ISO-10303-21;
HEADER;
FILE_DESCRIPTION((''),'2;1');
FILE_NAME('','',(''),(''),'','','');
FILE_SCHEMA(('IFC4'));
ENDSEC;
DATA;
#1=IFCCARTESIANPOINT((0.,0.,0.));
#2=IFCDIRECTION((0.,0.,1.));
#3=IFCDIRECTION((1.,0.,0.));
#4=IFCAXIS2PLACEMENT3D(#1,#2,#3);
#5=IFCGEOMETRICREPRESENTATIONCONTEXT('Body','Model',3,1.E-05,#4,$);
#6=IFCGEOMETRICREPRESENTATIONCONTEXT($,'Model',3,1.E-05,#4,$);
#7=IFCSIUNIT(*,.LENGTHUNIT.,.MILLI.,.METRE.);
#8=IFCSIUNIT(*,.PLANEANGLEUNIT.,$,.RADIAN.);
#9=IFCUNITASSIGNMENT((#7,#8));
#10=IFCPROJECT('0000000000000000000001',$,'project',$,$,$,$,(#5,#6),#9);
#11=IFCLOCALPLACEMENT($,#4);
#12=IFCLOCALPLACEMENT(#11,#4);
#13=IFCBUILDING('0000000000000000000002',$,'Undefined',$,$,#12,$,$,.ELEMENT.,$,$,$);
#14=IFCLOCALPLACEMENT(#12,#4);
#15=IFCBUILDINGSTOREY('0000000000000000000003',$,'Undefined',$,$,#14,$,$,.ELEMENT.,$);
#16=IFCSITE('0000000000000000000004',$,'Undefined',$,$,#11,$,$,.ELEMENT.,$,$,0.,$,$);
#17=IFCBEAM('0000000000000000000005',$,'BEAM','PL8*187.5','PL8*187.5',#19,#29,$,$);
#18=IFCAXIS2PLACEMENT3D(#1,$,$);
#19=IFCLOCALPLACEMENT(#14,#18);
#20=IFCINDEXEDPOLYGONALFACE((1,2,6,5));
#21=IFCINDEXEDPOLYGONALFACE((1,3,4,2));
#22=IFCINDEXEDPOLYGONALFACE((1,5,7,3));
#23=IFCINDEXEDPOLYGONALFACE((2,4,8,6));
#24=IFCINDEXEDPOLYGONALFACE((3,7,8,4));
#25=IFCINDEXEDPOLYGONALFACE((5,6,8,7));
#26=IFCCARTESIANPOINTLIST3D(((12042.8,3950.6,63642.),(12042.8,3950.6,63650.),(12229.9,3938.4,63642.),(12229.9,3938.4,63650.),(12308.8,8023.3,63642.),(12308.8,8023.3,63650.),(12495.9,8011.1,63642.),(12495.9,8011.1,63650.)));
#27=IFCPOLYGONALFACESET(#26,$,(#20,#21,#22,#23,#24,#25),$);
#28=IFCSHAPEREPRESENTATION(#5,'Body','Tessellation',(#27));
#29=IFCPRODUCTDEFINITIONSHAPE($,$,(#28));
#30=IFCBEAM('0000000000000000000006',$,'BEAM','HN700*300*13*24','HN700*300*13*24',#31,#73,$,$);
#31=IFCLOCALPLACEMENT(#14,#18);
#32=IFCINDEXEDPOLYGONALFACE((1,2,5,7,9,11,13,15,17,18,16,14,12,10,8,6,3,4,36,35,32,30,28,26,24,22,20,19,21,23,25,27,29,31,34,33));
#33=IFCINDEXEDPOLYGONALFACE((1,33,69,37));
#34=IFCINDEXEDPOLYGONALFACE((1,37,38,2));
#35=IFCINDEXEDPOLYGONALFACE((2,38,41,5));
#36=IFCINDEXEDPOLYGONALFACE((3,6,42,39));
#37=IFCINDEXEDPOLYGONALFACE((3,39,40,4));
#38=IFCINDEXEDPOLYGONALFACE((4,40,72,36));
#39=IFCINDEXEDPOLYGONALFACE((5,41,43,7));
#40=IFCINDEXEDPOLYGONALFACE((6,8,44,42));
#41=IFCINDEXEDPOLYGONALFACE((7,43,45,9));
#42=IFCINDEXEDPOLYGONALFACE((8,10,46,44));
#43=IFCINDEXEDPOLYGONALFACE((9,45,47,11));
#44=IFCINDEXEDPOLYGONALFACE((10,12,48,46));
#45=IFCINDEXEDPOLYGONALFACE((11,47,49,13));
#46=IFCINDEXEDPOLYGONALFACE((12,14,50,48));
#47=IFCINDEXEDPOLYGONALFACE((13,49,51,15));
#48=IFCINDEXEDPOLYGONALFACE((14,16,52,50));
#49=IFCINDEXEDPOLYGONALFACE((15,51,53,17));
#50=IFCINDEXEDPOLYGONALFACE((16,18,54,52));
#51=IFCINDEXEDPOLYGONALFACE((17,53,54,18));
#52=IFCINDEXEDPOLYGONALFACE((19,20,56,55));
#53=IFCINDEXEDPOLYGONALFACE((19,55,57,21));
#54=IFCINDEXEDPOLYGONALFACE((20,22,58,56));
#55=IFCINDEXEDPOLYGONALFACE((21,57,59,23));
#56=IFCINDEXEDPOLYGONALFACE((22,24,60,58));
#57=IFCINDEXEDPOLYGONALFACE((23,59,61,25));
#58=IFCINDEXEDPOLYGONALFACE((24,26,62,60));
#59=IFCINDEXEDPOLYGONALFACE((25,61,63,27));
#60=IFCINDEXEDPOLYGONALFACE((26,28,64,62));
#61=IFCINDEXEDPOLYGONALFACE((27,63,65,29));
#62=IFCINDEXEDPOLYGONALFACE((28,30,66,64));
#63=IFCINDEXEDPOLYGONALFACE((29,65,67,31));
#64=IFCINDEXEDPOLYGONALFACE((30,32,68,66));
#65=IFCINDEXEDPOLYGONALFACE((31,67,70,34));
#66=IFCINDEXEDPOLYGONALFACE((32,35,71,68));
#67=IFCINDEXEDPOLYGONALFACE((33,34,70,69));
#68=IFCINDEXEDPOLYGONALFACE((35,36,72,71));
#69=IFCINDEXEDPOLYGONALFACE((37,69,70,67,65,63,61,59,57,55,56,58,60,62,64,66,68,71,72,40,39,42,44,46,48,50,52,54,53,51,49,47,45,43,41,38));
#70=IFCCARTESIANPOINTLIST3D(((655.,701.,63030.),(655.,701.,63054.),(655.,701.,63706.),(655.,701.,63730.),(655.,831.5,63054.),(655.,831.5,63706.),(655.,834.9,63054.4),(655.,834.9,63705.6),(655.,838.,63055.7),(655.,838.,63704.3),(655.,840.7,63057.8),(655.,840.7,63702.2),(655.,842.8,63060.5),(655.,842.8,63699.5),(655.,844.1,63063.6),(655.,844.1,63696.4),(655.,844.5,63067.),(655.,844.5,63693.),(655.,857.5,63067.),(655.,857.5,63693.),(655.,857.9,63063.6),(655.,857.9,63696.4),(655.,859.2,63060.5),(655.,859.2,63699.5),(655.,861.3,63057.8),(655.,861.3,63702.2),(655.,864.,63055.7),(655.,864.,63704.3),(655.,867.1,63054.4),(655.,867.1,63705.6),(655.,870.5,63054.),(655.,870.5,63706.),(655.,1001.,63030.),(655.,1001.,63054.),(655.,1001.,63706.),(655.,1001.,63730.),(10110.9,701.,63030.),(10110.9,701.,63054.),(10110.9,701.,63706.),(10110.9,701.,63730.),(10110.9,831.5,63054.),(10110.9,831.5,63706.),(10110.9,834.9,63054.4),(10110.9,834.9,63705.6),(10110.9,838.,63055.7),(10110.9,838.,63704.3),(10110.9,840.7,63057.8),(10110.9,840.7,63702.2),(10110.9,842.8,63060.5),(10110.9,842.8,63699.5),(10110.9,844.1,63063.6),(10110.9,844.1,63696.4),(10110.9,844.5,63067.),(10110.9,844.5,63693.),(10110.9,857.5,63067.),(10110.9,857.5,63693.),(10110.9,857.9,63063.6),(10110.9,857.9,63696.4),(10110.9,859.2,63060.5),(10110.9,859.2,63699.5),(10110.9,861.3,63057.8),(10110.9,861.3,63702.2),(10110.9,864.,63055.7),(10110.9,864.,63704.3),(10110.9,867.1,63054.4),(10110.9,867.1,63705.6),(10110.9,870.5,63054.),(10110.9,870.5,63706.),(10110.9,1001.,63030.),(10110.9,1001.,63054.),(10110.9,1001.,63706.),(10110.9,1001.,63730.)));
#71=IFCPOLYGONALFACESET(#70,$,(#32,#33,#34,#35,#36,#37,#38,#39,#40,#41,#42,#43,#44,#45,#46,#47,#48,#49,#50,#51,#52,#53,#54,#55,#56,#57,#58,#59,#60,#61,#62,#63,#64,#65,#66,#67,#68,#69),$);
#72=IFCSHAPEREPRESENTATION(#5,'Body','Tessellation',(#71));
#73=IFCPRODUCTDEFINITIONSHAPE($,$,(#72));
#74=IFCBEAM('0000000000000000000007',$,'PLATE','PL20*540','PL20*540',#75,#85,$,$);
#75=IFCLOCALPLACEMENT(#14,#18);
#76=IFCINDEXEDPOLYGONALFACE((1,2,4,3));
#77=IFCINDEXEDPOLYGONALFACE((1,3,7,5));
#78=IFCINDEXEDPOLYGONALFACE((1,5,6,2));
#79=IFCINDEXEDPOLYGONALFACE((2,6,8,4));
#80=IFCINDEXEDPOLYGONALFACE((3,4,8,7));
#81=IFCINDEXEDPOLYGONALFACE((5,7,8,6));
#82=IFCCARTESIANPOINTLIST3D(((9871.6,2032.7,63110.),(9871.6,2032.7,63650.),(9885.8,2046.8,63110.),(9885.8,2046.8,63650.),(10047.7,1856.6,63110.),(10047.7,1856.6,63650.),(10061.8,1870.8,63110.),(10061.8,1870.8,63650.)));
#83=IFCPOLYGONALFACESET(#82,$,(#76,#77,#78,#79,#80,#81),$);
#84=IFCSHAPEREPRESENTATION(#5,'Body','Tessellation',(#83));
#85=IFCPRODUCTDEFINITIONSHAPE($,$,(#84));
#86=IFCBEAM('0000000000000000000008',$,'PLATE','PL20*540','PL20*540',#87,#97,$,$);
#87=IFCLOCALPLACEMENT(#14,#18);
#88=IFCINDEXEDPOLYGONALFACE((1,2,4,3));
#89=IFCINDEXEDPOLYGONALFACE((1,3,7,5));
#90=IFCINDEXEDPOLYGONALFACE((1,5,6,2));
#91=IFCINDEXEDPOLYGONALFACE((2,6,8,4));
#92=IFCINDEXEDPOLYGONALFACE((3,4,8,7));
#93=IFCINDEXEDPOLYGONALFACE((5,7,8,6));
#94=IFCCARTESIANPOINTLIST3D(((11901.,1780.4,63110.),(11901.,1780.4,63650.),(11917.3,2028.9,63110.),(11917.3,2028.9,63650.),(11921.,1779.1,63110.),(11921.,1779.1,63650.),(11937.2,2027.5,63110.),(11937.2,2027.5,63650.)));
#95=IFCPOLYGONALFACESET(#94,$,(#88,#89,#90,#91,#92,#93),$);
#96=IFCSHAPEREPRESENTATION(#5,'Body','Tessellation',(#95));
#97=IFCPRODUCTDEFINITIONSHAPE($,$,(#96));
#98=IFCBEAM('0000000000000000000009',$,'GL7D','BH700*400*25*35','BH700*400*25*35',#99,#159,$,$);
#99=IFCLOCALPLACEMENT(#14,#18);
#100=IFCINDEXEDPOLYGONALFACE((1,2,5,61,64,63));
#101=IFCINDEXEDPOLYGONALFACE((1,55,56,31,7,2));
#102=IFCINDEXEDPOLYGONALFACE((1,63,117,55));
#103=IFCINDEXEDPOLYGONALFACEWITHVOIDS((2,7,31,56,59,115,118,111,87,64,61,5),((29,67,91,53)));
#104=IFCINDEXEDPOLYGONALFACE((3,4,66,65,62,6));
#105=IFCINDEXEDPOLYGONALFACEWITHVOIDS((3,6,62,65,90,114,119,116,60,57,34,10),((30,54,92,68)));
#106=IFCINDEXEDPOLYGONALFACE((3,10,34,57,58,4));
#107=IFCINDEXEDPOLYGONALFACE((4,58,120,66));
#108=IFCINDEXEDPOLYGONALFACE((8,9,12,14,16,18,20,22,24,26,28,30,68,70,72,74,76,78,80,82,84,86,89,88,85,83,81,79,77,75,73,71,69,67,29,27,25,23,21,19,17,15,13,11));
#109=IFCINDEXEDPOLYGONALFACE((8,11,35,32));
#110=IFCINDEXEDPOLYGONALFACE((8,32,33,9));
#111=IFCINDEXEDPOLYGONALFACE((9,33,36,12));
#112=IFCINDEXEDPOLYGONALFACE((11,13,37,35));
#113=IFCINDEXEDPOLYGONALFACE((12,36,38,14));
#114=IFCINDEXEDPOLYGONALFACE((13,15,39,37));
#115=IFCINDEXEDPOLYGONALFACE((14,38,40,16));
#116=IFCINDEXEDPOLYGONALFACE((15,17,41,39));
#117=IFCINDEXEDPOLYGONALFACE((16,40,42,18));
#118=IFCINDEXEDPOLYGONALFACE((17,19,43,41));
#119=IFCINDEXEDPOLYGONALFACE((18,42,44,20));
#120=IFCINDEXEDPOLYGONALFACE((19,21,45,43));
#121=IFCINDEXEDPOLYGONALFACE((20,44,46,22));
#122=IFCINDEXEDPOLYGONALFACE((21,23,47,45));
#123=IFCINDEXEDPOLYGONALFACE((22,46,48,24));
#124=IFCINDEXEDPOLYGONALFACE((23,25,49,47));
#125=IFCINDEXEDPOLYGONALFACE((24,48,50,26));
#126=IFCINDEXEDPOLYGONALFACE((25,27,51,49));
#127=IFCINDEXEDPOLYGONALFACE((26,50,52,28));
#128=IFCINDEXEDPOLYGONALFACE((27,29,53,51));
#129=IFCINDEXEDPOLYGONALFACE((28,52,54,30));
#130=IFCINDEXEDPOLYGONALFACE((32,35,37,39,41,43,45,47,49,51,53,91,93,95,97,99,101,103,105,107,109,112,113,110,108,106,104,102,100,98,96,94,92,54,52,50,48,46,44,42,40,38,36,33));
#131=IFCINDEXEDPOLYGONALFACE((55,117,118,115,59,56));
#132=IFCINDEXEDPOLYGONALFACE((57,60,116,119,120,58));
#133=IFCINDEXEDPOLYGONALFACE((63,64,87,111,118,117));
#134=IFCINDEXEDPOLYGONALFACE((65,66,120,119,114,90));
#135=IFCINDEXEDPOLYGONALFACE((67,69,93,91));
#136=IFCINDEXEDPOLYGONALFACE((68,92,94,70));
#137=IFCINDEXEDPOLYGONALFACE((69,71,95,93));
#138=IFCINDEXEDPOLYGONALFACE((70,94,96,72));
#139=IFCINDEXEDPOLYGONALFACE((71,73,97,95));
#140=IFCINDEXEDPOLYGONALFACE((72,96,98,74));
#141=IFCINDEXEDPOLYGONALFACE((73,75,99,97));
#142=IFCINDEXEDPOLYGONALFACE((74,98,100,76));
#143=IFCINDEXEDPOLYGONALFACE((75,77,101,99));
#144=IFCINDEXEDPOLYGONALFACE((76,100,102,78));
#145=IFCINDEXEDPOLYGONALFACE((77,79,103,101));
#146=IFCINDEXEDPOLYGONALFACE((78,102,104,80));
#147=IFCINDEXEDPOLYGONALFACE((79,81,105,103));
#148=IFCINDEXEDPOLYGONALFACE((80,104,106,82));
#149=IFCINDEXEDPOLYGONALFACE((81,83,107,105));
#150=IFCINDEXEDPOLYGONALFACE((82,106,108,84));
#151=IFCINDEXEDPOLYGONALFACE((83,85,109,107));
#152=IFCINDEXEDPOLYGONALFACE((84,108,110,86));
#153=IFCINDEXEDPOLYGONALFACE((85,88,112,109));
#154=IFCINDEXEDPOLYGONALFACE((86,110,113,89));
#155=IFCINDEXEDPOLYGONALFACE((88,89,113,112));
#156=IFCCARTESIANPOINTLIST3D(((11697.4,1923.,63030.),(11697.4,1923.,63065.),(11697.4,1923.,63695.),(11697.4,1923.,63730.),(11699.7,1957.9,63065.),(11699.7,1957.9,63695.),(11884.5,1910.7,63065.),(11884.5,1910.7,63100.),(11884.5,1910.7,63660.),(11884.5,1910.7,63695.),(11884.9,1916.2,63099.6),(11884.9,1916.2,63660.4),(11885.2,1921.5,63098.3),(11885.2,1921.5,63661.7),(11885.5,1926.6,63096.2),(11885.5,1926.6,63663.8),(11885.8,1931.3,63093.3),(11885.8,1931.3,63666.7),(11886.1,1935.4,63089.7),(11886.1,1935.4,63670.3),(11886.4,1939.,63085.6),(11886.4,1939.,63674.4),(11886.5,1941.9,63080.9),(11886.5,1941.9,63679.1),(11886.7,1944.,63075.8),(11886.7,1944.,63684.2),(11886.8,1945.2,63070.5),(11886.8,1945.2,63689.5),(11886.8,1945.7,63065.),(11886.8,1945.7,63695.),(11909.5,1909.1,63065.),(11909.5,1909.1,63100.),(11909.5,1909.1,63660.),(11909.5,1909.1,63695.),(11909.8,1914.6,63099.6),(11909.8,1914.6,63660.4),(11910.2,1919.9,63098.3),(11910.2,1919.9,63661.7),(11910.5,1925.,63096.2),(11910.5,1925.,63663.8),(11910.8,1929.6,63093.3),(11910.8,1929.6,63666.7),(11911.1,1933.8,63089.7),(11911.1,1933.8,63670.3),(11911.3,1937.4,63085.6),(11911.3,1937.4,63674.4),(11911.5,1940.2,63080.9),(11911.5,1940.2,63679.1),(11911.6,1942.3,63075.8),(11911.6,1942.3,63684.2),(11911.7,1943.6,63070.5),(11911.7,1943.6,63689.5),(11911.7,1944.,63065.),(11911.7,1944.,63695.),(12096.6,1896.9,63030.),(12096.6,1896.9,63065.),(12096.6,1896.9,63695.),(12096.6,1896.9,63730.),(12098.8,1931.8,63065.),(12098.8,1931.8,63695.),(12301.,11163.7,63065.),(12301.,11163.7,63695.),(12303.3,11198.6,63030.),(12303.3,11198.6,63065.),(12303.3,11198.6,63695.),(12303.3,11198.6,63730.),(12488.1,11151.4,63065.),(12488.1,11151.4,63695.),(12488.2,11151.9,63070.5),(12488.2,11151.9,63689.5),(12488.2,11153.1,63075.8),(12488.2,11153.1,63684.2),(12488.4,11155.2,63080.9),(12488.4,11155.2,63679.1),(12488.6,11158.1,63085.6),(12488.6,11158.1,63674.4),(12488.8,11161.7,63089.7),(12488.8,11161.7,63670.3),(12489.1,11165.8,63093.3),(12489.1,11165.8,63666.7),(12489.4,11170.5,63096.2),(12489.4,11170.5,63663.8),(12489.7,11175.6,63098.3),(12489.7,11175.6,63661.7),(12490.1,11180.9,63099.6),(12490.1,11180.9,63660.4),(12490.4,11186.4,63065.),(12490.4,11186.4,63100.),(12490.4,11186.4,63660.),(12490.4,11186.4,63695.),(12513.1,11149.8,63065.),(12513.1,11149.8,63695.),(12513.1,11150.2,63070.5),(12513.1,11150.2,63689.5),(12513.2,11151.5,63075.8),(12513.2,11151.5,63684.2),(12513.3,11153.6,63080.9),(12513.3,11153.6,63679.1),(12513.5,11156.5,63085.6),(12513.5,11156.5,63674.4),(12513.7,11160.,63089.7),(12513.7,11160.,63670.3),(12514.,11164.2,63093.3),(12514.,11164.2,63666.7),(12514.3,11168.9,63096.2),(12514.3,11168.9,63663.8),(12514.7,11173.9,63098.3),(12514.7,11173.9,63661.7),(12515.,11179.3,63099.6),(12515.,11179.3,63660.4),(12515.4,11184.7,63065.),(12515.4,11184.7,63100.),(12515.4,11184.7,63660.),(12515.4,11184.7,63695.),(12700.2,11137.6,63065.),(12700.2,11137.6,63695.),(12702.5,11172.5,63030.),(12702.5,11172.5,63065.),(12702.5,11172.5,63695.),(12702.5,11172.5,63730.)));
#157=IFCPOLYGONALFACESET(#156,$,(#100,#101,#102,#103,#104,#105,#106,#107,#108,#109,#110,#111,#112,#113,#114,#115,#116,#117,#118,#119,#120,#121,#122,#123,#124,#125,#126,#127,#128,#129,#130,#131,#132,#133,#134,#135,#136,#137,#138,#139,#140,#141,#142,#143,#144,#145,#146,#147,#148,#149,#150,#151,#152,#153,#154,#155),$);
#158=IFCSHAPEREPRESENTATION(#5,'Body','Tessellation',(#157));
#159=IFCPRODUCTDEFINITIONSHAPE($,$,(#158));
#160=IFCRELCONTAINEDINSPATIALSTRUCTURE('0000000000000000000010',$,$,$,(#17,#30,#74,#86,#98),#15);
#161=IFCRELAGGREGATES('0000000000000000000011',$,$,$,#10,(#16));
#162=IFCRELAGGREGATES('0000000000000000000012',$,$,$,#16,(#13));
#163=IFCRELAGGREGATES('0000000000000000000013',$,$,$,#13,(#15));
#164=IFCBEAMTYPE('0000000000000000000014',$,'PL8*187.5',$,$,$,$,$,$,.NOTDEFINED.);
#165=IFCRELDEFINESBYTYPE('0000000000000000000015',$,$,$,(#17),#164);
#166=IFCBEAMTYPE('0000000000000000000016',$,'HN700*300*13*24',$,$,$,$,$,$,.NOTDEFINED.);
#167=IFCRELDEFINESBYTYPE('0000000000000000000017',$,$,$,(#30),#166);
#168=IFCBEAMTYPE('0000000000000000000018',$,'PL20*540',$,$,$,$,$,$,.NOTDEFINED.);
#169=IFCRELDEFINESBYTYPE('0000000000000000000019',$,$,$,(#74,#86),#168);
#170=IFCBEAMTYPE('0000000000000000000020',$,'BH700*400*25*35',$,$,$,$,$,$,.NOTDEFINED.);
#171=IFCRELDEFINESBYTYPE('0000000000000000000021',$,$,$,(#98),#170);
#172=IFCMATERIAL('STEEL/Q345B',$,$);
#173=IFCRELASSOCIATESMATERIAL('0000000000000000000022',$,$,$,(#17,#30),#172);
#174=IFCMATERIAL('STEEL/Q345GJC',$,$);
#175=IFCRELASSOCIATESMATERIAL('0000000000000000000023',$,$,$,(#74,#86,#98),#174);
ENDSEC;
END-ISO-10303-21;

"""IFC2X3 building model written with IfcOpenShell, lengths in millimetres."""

from ifc_helpers import new_model, si_unit, frame, origin_with_axes, origin_2d_with_axis, place, context, project, spatial, polyline, rectangle, i_section, outline, extrude, material, type_object, element, save


model = new_model("IFC2X3")

# Units and contexts
model_context_1 = context("Model", 3, precision=1e-05, world=origin_with_axes(), identifier="Body")
model_context_2 = context("Model", 3, precision=1e-05, world=origin_with_axes())
ifc_project = project(units=[si_unit("LENGTHUNIT", "METRE", prefix="MILLI"), si_unit("PLANEANGLEUNIT", "RADIAN")], contexts=[model_context_1, model_context_2])

# Site, building, storey
site_placement = place(None, origin_with_axes())
site = spatial("IfcSite", under=ifc_project, at=site_placement, Name="Undefined", CompositionType="ELEMENT", RefElevation=0.0)
building_placement = place(site_placement, origin_with_axes())
building = spatial("IfcBuilding", under=site, at=building_placement, Name="Undefined", CompositionType="ELEMENT")
storey_placement = place(building_placement, origin_with_axes())
storey = spatial("IfcBuildingStorey", under=building, at=storey_placement, Name="Undefined", CompositionType="ELEMENT")

# Beams
ifc_material_1 = material(Name="STEEL/Q345B")
beam_type_1 = type_object("IfcBeamType", Name="PL8*187.5", PredefinedType="NOTDEFINED")
beam_1_placement = place(storey_placement, frame((12136.4, 3944.5, 63646.0), z_axis=(-0.997873, 0.065184, 0.0), x_axis=(0.065184, 0.997873, 0.0)))
element("IfcBeam", 1, at=beam_1_placement, inside=storey, type_object=beam_type_1, material=ifc_material_1, Name="BEAM", Description="PL8*187.5", ObjectType="PL8*187.5", context=model_context_1, shape_type="SweptSolid", body=[
    extrude(rectangle(XDim=8.0, YDim=187.5, at=origin_2d_with_axis()), frame((4081.3, 0.0, 0.0), z_axis=(-1.0, 0.0, 0.0), x_axis=(0.0, -1.0, 0.0)), (0.0, 0.0, 1.0), 4081.3),
])
beam_type_2 = type_object("IfcBeamType", Name="HN700*300*13*24", PredefinedType="NOTDEFINED")
beam_2_placement = place(storey_placement, frame((10110.9, 851.0, 63380.0), z_axis=(0.0, 0.0, 1.0), x_axis=(-1.0, 0.0, 0.0)))
element("IfcBeam", 2, at=beam_2_placement, inside=storey, type_object=beam_type_2, material=ifc_material_1, Name="BEAM", Description="HN700*300*13*24", ObjectType="HN700*300*13*24", context=model_context_1, shape_type="SweptSolid", body=[
    extrude(i_section(OverallWidth=300.0, OverallDepth=700.0, WebThickness=13.0, FlangeThickness=24.0, FilletRadius=13.0, at=origin_2d_with_axis()), frame((9455.9, 0.0, 0.0), z_axis=(-1.0, 0.0, 0.0), x_axis=(0.0, -1.0, 0.0)), (0.0, 0.0, 1.0), 9455.9),
])
ifc_material_2 = material(Name="STEEL/Q345GJC")
beam_type_3 = type_object("IfcBeamType", Name="PL20*540", PredefinedType="NOTDEFINED")
beam_3_placement = place(storey_placement, frame((10054.8, 1863.7, 63380.0), z_axis=(0.0, 0.0, 1.0), x_axis=(-0.707107, 0.707107, 0.0)))
element("IfcBeam", 3, at=beam_3_placement, inside=storey, type_object=beam_type_3, material=ifc_material_2, Name="PLATE", Description="PL20*540", ObjectType="PL20*540", context=model_context_1, shape_type="SweptSolid", body=[
    extrude(rectangle(XDim=20.0, YDim=540.0, at=origin_2d_with_axis()), frame((249.0, 0.0, 0.0), z_axis=(-1.0, 0.0, 0.0), x_axis=(0.0, -1.0, 0.0)), (0.0, 0.0, 1.0), 249.0),
])
beam_4_placement = place(storey_placement, frame((11911.0, 1779.7, 63380.0), z_axis=(0.0, 0.0, 1.0), x_axis=(0.065184, 0.997873, 0.0)))
element("IfcBeam", 4, at=beam_4_placement, inside=storey, type_object=beam_type_3, material=ifc_material_2, Name="PLATE", Description="PL20*540", ObjectType="PL20*540", context=model_context_1, shape_type="SweptSolid", body=[
    extrude(rectangle(XDim=20.0, YDim=540.0, at=origin_2d_with_axis()), frame((249.0, 0.0, 0.0), z_axis=(-1.0, 0.0, 0.0), x_axis=(0.0, -1.0, 0.0)), (0.0, 0.0, 1.0), 249.0),
])

# Beam, openings
beam_type_4 = type_object("IfcBeamType", Name="BH700*400*25*35", PredefinedType="NOTDEFINED")
beam_5_placement = place(storey_placement, frame((11837.0, 992.3, 63380.0), z_axis=(0.0, 0.0, 1.0), x_axis=(0.065184, 0.997873, 0.0)))
beam_5 = element("IfcBeam", 5, at=beam_5_placement, inside=storey, type_object=beam_type_4, material=ifc_material_2, Name="GL7D", Description="BH700*400*25*35", ObjectType="BH700*400*25*35", context=model_context_1, shape_type="SweptSolid", body=[
    extrude(i_section(OverallWidth=400.0, OverallDepth=700.0, WebThickness=25.0, FlangeThickness=35.0, at=origin_2d_with_axis()), frame((10215.0, 0.0, 0.0), z_axis=(-1.0, 0.0, 0.0), x_axis=(0.0, -1.0, 0.0)), (0.0, 0.0, 1.0), 9295.4),
])
opening_1_placement = place(storey_placement, frame((11837.0, 992.3, 63380.0), z_axis=(0.0, 0.0, 1.0), x_axis=(0.065184, 0.997873, 0.0)))
element("IfcOpeningElement", 6, at=opening_1_placement, cuts=beam_5, ObjectType="Recess", context=model_context_1, shape_type="SweptSolid", body=[
    extrude(outline(polyline([(0.0, 0.0), (37.0, 0.0), (37.0, 35.0), (35.0, 35.0), (29.5, 34.6), (24.2, 33.3), (19.1, 31.2), (14.4, 28.3), (10.3, 24.7), (6.7, 20.6), (3.8, 15.9), (1.7, 10.8), (0.4, 5.5), (0.0, 0.0), (0.0, 0.0)])), frame((10180.0, -200.0, 315.0), z_axis=(0.0, 1.0, 0.0), x_axis=(1.0, 0.0, 0.0)), (0.0, 0.0, 1.0), 400.0),
])
opening_2_placement = place(storey_placement, frame((11837.0, 992.3, 63380.0), z_axis=(0.0, 0.0, 1.0), x_axis=(0.065184, 0.997873, 0.0)))
element("IfcOpeningElement", 7, at=opening_2_placement, cuts=beam_5, ObjectType="Recess", context=model_context_1, shape_type="SweptSolid", body=[
    extrude(outline(polyline([(0.0, 0.0), (37.0, 0.0), (36.6, 5.5), (35.3, 10.8), (33.2, 15.9), (30.3, 20.6), (26.7, 24.7), (22.6, 28.3), (17.9, 31.2), (12.8, 33.3), (7.5, 34.6), (2.0, 35.0), (0.0, 35.0), (0.0, 0.0)])), frame((10217.0, -200.0, -315.0), z_axis=(0.0, 1.0, 0.0), x_axis=(-1.0, 0.0, 0.0)), (0.0, 0.0, 1.0), 400.0),
])
opening_3_placement = place(storey_placement, frame((11837.0, 992.3, 63380.0), z_axis=(0.0, 0.0, 1.0), x_axis=(0.065184, 0.997873, 0.0)))
element("IfcOpeningElement", 8, at=opening_3_placement, cuts=beam_5, ObjectType="Recess", context=model_context_1, shape_type="SweptSolid", body=[
    extrude(outline(polyline([(0.0, 0.0), (37.0, 0.0), (37.0, 35.0), (35.0, 35.0), (29.5, 34.6), (24.2, 33.3), (19.1, 31.2), (14.4, 28.3), (10.3, 24.7), (6.7, 20.6), (3.8, 15.9), (1.7, 10.8), (0.4, 5.5), (0.0, 0.0), (0.0, 0.0)])), frame((954.6, 200.0, 315.0), z_axis=(0.0, -1.0, 0.0), x_axis=(-1.0, 0.0, 0.0)), (0.0, 0.0, 1.0), 400.0),
])
opening_4_placement = place(storey_placement, frame((11837.0, 992.3, 63380.0), z_axis=(0.0, 0.0, 1.0), x_axis=(0.065184, 0.997873, 0.0)))
element("IfcOpeningElement", 9, at=opening_4_placement, cuts=beam_5, ObjectType="Recess", context=model_context_1, shape_type="SweptSolid", body=[
    extrude(outline(polyline([(0.0, 0.0), (37.0, 0.0), (36.6, 5.5), (35.3, 10.8), (33.2, 15.9), (30.3, 20.6), (26.7, 24.7), (22.6, 28.3), (17.9, 31.2), (12.8, 33.3), (7.5, 34.6), (2.0, 35.0), (0.0, 35.0), (0.0, 0.0)])), frame((917.6, 200.0, -315.0), z_axis=(0.0, -1.0, 0.0), x_axis=(1.0, 0.0, 0.0)), (0.0, 0.0, 1.0), 400.0),
])
opening_5_placement = place(storey_placement, frame((11837.0, 992.3, 63380.0), z_axis=(0.0, 0.0, 1.0), x_axis=(0.065184, 0.997873, 0.0)))
element("IfcOpeningElement", 10, at=opening_5_placement, cuts=beam_5, ObjectType="Recess", context=model_context_1, shape_type="SweptSolid", body=[
    extrude(outline(polyline([(0.0, 0.0), (37.0, 0.0), (37.0, 35.0), (35.0, 35.0), (29.5, 34.6), (24.2, 33.3), (19.1, 31.2), (14.4, 28.3), (10.3, 24.7), (6.7, 20.6), (3.8, 15.9), (1.7, 10.8), (0.4, 5.5), (0.0, 0.0), (0.0, 0.0)])), frame((954.6, 200.0, 315.0), z_axis=(0.0, -1.0, 0.0), x_axis=(-1.0, 0.0, 0.0)), (0.0, 0.0, 1.0), 400.0),
])
opening_6_placement = place(storey_placement, frame((11837.0, 992.3, 63380.0), z_axis=(0.0, 0.0, 1.0), x_axis=(0.065184, 0.997873, 0.0)))
element("IfcOpeningElement", 11, at=opening_6_placement, cuts=beam_5, ObjectType="Recess", context=model_context_1, shape_type="SweptSolid", body=[
    extrude(outline(polyline([(0.0, 0.0), (37.0, 0.0), (36.6, 5.5), (35.3, 10.8), (33.2, 15.9), (30.3, 20.6), (26.7, 24.7), (22.6, 28.3), (17.9, 31.2), (12.8, 33.3), (7.5, 34.6), (2.0, 35.0), (0.0, 35.0), (0.0, 0.0)])), frame((917.6, 200.0, -315.0), z_axis=(0.0, -1.0, 0.0), x_axis=(1.0, 0.0, 0.0)), (0.0, 0.0, 1.0), 400.0),
])

save(model, "model.ifc")
